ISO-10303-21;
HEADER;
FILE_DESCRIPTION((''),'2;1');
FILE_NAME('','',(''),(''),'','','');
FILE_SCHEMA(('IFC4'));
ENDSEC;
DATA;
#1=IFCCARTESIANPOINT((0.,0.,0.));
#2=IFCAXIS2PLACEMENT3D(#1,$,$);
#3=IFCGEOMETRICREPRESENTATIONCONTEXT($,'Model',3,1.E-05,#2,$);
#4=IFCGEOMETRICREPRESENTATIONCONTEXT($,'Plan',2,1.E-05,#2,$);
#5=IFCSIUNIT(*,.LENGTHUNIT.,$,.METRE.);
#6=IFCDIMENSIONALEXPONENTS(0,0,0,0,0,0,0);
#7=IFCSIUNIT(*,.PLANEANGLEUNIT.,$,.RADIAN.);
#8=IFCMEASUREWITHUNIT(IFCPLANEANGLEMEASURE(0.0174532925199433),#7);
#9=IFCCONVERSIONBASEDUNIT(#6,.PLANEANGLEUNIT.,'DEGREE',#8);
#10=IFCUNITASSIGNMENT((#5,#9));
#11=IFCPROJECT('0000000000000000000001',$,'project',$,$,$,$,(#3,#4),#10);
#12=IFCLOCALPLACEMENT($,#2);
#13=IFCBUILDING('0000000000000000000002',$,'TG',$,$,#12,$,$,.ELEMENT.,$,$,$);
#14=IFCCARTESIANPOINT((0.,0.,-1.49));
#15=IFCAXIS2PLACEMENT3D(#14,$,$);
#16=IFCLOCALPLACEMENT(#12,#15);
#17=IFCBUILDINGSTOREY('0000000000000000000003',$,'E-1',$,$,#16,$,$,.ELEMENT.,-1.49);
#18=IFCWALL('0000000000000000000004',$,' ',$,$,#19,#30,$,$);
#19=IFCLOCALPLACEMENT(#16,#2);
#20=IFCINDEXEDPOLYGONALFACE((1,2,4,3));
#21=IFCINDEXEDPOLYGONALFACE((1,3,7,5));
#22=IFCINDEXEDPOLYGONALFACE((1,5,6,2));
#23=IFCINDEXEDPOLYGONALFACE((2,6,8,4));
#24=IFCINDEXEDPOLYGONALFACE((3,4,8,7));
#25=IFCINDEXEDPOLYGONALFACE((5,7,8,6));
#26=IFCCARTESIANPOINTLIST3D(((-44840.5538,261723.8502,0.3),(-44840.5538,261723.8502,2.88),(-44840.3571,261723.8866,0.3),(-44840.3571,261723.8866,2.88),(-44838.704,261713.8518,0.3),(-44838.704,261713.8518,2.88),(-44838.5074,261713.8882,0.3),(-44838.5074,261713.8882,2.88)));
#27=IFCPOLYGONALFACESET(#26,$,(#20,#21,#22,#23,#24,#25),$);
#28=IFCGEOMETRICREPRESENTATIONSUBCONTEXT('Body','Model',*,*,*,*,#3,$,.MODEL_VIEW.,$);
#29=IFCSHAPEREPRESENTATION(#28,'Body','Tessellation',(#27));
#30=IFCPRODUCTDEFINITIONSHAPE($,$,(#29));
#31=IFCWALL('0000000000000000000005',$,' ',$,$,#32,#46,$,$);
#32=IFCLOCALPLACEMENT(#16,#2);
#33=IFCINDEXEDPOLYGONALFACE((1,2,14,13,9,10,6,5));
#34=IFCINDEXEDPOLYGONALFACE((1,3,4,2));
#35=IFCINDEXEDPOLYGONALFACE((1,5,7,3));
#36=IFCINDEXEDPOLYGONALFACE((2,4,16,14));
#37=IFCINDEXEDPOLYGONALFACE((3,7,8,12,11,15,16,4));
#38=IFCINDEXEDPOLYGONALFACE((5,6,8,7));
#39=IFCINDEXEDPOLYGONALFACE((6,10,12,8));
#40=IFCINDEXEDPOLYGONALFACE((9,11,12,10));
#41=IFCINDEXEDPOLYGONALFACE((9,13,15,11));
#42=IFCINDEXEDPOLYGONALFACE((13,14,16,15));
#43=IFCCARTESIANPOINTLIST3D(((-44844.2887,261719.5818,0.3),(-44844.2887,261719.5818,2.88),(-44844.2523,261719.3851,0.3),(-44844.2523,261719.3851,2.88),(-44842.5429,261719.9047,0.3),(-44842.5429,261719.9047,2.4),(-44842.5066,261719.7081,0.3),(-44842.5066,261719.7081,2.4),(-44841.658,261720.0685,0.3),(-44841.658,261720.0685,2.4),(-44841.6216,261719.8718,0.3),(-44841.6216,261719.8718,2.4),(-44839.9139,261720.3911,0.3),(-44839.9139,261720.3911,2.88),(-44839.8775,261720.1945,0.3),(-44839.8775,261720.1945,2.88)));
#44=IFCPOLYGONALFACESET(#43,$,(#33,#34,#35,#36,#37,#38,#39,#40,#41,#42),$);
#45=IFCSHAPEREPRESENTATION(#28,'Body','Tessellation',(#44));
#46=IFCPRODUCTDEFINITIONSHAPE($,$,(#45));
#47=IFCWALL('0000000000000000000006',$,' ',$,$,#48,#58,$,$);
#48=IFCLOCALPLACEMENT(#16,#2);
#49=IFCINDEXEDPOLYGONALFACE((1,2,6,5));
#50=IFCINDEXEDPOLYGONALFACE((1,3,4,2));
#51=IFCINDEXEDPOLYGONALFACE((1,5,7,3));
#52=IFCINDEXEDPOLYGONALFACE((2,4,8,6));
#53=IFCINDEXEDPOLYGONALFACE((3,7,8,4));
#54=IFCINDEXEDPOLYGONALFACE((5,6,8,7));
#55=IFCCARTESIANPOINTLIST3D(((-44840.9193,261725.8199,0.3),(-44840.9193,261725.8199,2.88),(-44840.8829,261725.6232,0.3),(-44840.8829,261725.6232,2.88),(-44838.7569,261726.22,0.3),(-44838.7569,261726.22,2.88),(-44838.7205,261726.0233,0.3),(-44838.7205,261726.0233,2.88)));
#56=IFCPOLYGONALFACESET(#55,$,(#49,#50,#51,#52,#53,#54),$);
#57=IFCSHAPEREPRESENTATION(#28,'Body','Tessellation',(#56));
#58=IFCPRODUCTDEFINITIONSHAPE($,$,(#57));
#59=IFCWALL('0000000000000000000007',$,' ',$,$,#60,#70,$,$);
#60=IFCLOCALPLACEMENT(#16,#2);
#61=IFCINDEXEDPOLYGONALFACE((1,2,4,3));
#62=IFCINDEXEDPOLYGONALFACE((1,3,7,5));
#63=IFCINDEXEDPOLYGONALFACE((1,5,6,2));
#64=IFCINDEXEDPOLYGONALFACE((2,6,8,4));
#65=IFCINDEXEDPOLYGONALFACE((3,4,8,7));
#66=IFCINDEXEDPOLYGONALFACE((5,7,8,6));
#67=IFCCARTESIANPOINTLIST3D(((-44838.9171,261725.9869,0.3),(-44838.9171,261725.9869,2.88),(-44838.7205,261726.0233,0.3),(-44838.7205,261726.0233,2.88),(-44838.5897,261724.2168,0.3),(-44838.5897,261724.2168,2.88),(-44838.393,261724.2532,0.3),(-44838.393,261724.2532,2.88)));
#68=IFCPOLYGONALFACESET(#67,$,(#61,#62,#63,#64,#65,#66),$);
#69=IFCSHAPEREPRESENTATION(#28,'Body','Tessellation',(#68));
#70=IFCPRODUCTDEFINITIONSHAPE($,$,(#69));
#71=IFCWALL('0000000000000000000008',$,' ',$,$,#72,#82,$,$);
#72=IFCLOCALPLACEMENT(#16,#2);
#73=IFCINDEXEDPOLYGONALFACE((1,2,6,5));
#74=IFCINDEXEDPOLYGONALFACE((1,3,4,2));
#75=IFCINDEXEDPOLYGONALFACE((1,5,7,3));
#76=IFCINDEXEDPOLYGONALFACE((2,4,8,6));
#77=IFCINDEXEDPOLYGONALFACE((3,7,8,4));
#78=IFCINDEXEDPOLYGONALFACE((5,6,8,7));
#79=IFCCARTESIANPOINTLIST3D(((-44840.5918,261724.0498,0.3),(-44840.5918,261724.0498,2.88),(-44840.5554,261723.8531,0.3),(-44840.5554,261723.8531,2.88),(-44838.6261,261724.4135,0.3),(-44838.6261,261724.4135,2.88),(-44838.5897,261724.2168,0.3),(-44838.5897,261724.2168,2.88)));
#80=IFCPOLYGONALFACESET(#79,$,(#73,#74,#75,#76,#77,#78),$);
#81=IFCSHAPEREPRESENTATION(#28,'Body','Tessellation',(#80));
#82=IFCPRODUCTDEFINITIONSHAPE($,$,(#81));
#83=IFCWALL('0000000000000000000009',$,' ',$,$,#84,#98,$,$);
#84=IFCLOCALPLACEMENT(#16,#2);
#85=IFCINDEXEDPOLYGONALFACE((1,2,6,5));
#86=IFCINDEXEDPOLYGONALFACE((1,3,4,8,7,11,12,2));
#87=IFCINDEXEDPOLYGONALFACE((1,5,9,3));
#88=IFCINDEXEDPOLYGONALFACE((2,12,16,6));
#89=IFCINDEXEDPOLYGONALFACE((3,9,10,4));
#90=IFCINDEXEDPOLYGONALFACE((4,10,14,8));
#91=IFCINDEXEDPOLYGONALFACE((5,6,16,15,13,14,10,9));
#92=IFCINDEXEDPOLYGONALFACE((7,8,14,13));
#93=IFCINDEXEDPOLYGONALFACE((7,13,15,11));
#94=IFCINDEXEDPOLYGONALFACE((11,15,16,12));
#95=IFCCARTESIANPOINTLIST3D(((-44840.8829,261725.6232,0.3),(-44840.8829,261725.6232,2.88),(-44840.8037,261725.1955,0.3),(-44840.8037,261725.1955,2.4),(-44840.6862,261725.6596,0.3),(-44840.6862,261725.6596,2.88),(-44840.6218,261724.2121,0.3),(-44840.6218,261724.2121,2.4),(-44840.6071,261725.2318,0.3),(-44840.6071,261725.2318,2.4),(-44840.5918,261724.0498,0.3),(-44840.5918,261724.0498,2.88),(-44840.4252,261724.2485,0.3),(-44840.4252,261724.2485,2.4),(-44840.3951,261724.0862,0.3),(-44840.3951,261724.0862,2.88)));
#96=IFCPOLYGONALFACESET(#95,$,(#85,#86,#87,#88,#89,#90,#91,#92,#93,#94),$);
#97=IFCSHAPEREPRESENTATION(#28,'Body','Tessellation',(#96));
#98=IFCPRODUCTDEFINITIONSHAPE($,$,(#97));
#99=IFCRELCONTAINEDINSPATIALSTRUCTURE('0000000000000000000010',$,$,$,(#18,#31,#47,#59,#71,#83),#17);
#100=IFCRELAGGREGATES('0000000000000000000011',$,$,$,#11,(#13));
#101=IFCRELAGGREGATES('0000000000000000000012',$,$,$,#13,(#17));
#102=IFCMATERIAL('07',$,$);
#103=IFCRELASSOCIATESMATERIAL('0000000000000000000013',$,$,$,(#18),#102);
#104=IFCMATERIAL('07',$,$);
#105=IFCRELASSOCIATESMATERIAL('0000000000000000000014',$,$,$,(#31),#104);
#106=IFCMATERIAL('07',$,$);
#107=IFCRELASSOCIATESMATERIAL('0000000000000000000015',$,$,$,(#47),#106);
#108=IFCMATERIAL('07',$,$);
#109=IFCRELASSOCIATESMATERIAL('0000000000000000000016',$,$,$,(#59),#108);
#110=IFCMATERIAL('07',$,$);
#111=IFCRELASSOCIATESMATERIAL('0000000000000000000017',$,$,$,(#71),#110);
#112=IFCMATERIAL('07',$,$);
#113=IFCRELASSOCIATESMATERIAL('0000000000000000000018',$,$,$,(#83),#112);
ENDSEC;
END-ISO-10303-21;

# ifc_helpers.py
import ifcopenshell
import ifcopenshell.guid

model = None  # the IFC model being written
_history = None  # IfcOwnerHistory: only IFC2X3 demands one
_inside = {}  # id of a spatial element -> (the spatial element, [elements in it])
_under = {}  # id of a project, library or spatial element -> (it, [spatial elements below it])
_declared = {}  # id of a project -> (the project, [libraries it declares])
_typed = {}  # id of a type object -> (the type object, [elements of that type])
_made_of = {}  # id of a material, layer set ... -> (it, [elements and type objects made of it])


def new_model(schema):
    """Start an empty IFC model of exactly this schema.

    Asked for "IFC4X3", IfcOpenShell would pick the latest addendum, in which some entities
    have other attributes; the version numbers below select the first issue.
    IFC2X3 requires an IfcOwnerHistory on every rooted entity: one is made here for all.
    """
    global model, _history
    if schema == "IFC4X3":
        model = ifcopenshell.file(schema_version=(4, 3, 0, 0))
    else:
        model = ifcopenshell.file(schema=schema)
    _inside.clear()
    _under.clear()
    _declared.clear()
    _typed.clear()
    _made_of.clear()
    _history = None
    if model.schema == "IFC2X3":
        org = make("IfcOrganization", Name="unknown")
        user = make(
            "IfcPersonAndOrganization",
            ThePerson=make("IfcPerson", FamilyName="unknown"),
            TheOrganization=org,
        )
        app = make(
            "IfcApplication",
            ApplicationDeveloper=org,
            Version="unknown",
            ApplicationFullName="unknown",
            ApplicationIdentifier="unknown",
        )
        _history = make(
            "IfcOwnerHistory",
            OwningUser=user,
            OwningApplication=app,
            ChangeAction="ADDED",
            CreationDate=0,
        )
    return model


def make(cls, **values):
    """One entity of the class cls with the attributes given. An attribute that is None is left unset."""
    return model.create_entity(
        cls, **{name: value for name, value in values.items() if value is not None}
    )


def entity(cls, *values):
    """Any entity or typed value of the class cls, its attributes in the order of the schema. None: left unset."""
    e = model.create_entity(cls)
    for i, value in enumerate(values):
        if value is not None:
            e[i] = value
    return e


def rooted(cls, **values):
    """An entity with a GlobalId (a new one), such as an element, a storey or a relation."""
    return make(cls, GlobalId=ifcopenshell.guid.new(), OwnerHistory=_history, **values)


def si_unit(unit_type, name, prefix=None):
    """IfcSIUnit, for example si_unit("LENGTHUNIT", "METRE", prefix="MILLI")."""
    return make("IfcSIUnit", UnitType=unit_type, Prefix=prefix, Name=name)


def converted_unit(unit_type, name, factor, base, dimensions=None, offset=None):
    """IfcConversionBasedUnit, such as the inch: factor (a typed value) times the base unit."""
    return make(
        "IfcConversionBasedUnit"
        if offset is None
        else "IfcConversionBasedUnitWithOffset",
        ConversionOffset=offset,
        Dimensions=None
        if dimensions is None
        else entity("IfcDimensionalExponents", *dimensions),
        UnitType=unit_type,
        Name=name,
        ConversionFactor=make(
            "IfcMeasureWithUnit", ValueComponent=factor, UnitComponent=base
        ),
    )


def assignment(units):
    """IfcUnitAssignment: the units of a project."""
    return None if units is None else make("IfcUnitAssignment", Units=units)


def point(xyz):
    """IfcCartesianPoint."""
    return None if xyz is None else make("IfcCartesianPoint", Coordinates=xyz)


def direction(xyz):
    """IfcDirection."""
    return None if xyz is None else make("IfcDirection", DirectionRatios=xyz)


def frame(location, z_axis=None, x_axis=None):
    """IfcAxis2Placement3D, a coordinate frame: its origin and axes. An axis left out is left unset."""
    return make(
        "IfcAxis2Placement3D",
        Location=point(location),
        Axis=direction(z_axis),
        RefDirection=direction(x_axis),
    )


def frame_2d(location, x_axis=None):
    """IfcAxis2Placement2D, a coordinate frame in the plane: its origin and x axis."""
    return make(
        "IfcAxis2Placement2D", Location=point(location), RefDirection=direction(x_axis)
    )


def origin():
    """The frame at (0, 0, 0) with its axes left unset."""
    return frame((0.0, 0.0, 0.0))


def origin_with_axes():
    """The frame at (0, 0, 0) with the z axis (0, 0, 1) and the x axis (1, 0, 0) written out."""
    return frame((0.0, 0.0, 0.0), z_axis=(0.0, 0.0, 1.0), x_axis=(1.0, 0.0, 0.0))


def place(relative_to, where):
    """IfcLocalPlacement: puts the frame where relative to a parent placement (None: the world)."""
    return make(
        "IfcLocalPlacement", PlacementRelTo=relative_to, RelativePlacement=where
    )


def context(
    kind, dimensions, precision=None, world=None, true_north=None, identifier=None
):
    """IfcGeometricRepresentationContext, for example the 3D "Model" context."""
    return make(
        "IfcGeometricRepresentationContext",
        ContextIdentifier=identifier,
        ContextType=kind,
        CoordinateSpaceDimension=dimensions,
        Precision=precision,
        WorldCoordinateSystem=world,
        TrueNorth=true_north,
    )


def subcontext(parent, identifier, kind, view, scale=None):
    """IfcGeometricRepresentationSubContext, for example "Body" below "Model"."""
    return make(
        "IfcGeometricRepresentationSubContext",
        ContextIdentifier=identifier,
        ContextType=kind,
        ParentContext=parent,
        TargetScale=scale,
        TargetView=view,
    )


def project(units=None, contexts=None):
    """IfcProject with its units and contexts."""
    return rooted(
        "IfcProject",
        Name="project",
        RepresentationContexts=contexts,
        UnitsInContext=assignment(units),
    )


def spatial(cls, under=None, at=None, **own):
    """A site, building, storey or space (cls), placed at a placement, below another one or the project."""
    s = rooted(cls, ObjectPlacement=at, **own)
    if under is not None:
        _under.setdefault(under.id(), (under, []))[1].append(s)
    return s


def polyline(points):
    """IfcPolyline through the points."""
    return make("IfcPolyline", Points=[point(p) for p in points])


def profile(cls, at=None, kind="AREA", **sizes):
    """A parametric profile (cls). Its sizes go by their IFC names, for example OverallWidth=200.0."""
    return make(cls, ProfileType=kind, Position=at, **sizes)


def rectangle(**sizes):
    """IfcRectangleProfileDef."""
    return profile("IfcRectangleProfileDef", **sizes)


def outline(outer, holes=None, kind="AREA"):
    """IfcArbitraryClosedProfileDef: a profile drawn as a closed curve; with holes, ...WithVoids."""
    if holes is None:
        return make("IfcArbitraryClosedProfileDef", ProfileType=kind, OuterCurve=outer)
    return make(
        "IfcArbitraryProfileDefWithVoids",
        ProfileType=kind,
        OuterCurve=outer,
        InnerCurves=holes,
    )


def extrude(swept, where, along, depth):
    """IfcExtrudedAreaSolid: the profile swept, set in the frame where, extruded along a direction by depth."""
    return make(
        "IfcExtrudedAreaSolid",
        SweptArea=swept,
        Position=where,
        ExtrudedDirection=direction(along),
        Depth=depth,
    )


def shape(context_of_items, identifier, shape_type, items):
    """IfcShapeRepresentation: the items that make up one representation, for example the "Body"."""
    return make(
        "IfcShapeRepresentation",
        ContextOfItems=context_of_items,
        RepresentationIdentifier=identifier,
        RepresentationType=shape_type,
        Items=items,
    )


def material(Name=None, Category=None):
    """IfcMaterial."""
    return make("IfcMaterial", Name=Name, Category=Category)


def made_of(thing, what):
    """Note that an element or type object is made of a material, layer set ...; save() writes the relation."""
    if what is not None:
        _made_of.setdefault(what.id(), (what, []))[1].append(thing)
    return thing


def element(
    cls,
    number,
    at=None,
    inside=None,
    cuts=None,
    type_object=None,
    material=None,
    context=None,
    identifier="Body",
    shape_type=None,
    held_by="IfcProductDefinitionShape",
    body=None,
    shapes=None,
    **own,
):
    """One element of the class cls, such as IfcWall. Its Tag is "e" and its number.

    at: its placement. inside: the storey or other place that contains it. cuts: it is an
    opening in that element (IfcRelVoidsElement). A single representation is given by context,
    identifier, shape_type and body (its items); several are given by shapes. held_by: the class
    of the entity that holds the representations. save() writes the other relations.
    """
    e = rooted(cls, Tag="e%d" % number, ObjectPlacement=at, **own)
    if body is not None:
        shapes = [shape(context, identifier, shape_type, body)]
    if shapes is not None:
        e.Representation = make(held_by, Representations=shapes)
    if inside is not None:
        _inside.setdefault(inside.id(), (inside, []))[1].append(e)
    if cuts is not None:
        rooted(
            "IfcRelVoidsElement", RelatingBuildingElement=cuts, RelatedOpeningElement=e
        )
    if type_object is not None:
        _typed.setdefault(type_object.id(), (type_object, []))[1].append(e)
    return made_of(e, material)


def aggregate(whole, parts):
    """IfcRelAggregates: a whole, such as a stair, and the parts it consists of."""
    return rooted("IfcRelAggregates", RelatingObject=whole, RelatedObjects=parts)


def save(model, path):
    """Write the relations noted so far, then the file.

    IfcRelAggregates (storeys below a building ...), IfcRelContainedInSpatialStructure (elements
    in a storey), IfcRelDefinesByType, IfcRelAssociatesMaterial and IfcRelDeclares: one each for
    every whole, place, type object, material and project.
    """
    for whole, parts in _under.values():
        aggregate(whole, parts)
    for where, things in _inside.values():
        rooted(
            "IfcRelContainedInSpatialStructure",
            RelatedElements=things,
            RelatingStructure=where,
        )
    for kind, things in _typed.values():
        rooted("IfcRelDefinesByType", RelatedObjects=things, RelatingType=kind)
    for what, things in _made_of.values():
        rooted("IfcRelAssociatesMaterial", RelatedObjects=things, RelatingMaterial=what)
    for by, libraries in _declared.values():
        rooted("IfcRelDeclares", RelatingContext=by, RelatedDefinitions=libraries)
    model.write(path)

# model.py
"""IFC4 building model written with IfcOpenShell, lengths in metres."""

from ifc_helpers import new_model, entity, si_unit, converted_unit, frame, frame_2d, origin, origin_with_axes, place, context, subcontext, project, spatial, polyline, rectangle, outline, extrude, material, element, save


model = new_model("IFC4")

# Units and contexts
model_context = context("Model", 3, precision=1e-05, world=origin())
plan_context = context("Plan", 2, precision=1e-05, world=origin())
body_context = subcontext(model_context, "Body", "Model", "MODEL_VIEW")
ifc_project = project(units=[si_unit("LENGTHUNIT", "METRE"), converted_unit("PLANEANGLEUNIT", "DEGREE", entity("IfcPlaneAngleMeasure", 0.0174532925199433), si_unit("PLANEANGLEUNIT", "RADIAN"), dimensions=[0, 0, 0, 0, 0, 0, 0])], contexts=[model_context, plan_context])

# Building, storey
building_placement = place(None, origin())
building = spatial("IfcBuilding", under=ifc_project, at=building_placement, Name="TG", CompositionType="ELEMENT")
storey_placement = place(building_placement, frame((0.0, 0.0, -1.49)))
storey = spatial("IfcBuildingStorey", under=building, at=storey_placement, Name="E-1", CompositionType="ELEMENT", Elevation=-1.49)

# Wall
ifc_material_1 = material(Name="07")
wall_1_placement = place(storey_placement, frame((-44840.5538, 261723.8502, 0.3), z_axis=(0.0, 0.0, 1.0), x_axis=(0.18192, -0.983313, 0.0)))
element("IfcWall", 1, at=wall_1_placement, inside=storey, material=ifc_material_1, Name=" ", context=body_context, shape_type="SweptSolid", body=[
    extrude(rectangle(XDim=10.1681, YDim=0.2, at=frame_2d((5.084, 0.1), x_axis=(1.0, 0.0))), origin_with_axes(), (0.0, 0.0, 1.0), 2.58),
])

# Wall, opening
ifc_material_2 = material(Name="07")
wall_2_placement = place(storey_placement, frame((-44839.9139, 261720.3911, 0.3), z_axis=(0.0, 0.0, 1.0), x_axis=(-0.983313, -0.18192, 0.0)))
wall_2 = element("IfcWall", 2, at=wall_2_placement, inside=storey, material=ifc_material_2, Name=" ", context=body_context, shape_type="SweptSolid", body=[
    extrude(rectangle(XDim=4.4491, YDim=0.2, at=frame_2d((2.2245, 0.1), x_axis=(1.0, 0.0))), origin_with_axes(), (0.0, 0.0, 1.0), 2.58),
])
opening_1_placement = place(wall_2_placement, frame((2.6737, 0.2, 0.0), z_axis=(0.0, -1.0, 0.0), x_axis=(0.0, 0.0, 1.0)))
element("IfcOpeningElement", 3, at=opening_1_placement, cuts=wall_2, ObjectType="Opening", context=body_context, shape_type="SweptSolid", body=[
    extrude(outline(polyline([(0.0, 0.9), (0.0, 0.0), (2.1, 0.0), (2.1, 0.9), (0.0, 0.9)])), origin_with_axes(), (0.0, 0.0, 1.0), 0.2),
])

# Walls
ifc_material_3 = material(Name="07")
wall_3_placement = place(storey_placement, frame((-44840.8829, 261725.6232, 0.3), z_axis=(0.0, 0.0, 1.0), x_axis=(0.983313, 0.18192, 0.0)))
element("IfcWall", 4, at=wall_3_placement, inside=storey, material=ifc_material_3, Name=" ", context=body_context, shape_type="SweptSolid", body=[
    extrude(rectangle(XDim=2.1991, YDim=0.2, at=frame_2d((1.0995, 0.1), x_axis=(1.0, 0.0))), origin_with_axes(), (0.0, 0.0, 1.0), 2.58),
])
ifc_material_4 = material(Name="07")
wall_4_placement = place(storey_placement, frame((-44838.9171, 261725.9869, 0.3), z_axis=(0.0, 0.0, 1.0), x_axis=(0.18192, -0.983313, 0.0)))
element("IfcWall", 5, at=wall_4_placement, inside=storey, material=ifc_material_4, Name=" ", context=body_context, shape_type="SweptSolid", body=[
    extrude(rectangle(XDim=1.8001, YDim=0.2, at=frame_2d((0.9001, 0.1), x_axis=(1.0, 0.0))), origin_with_axes(), (0.0, 0.0, 1.0), 2.58),
])
ifc_material_5 = material(Name="07")
wall_5_placement = place(storey_placement, frame((-44838.6261, 261724.4135, 0.3), z_axis=(0.0, 0.0, 1.0), x_axis=(-0.983313, -0.18192, 0.0)))
element("IfcWall", 6, at=wall_5_placement, inside=storey, material=ifc_material_5, Name=" ", context=body_context, shape_type="SweptSolid", body=[
    extrude(rectangle(XDim=1.9991, YDim=0.2, at=frame_2d((0.9995, 0.1), x_axis=(1.0, 0.0))), origin_with_axes(), (0.0, 0.0, 1.0), 2.58),
])

# Wall, opening
ifc_material_6 = material(Name="07")
wall_6_placement = place(storey_placement, frame((-44840.3951, 261724.0862, 0.3), z_axis=(0.0, 0.0, 1.0), x_axis=(-0.18192, 0.983313, 0.0)))
wall_6 = element("IfcWall", 7, at=wall_6_placement, inside=storey, material=ifc_material_6, Name=" ", context=body_context, shape_type="SweptSolid", body=[
    extrude(rectangle(XDim=1.6001, YDim=0.2, at=frame_2d((0.8001, 0.1), x_axis=(1.0, 0.0))), origin_with_axes(), (0.0, 0.0, 1.0), 2.58),
])
opening_2_placement = place(wall_6_placement, frame((1.1651, 0.2, 0.0), z_axis=(0.0, -1.0, 0.0), x_axis=(0.0, 0.0, 1.0)))
element("IfcOpeningElement", 8, at=opening_2_placement, cuts=wall_6, ObjectType="Opening", context=body_context, shape_type="SweptSolid", body=[
    extrude(outline(polyline([(0.0, 1.0), (2.1, 1.0), (2.1, 0.0), (0.0, 0.0), (0.0, 1.0)])), origin_with_axes(), (0.0, 0.0, 1.0), 0.2),
])

save(model, "model.ifc")
